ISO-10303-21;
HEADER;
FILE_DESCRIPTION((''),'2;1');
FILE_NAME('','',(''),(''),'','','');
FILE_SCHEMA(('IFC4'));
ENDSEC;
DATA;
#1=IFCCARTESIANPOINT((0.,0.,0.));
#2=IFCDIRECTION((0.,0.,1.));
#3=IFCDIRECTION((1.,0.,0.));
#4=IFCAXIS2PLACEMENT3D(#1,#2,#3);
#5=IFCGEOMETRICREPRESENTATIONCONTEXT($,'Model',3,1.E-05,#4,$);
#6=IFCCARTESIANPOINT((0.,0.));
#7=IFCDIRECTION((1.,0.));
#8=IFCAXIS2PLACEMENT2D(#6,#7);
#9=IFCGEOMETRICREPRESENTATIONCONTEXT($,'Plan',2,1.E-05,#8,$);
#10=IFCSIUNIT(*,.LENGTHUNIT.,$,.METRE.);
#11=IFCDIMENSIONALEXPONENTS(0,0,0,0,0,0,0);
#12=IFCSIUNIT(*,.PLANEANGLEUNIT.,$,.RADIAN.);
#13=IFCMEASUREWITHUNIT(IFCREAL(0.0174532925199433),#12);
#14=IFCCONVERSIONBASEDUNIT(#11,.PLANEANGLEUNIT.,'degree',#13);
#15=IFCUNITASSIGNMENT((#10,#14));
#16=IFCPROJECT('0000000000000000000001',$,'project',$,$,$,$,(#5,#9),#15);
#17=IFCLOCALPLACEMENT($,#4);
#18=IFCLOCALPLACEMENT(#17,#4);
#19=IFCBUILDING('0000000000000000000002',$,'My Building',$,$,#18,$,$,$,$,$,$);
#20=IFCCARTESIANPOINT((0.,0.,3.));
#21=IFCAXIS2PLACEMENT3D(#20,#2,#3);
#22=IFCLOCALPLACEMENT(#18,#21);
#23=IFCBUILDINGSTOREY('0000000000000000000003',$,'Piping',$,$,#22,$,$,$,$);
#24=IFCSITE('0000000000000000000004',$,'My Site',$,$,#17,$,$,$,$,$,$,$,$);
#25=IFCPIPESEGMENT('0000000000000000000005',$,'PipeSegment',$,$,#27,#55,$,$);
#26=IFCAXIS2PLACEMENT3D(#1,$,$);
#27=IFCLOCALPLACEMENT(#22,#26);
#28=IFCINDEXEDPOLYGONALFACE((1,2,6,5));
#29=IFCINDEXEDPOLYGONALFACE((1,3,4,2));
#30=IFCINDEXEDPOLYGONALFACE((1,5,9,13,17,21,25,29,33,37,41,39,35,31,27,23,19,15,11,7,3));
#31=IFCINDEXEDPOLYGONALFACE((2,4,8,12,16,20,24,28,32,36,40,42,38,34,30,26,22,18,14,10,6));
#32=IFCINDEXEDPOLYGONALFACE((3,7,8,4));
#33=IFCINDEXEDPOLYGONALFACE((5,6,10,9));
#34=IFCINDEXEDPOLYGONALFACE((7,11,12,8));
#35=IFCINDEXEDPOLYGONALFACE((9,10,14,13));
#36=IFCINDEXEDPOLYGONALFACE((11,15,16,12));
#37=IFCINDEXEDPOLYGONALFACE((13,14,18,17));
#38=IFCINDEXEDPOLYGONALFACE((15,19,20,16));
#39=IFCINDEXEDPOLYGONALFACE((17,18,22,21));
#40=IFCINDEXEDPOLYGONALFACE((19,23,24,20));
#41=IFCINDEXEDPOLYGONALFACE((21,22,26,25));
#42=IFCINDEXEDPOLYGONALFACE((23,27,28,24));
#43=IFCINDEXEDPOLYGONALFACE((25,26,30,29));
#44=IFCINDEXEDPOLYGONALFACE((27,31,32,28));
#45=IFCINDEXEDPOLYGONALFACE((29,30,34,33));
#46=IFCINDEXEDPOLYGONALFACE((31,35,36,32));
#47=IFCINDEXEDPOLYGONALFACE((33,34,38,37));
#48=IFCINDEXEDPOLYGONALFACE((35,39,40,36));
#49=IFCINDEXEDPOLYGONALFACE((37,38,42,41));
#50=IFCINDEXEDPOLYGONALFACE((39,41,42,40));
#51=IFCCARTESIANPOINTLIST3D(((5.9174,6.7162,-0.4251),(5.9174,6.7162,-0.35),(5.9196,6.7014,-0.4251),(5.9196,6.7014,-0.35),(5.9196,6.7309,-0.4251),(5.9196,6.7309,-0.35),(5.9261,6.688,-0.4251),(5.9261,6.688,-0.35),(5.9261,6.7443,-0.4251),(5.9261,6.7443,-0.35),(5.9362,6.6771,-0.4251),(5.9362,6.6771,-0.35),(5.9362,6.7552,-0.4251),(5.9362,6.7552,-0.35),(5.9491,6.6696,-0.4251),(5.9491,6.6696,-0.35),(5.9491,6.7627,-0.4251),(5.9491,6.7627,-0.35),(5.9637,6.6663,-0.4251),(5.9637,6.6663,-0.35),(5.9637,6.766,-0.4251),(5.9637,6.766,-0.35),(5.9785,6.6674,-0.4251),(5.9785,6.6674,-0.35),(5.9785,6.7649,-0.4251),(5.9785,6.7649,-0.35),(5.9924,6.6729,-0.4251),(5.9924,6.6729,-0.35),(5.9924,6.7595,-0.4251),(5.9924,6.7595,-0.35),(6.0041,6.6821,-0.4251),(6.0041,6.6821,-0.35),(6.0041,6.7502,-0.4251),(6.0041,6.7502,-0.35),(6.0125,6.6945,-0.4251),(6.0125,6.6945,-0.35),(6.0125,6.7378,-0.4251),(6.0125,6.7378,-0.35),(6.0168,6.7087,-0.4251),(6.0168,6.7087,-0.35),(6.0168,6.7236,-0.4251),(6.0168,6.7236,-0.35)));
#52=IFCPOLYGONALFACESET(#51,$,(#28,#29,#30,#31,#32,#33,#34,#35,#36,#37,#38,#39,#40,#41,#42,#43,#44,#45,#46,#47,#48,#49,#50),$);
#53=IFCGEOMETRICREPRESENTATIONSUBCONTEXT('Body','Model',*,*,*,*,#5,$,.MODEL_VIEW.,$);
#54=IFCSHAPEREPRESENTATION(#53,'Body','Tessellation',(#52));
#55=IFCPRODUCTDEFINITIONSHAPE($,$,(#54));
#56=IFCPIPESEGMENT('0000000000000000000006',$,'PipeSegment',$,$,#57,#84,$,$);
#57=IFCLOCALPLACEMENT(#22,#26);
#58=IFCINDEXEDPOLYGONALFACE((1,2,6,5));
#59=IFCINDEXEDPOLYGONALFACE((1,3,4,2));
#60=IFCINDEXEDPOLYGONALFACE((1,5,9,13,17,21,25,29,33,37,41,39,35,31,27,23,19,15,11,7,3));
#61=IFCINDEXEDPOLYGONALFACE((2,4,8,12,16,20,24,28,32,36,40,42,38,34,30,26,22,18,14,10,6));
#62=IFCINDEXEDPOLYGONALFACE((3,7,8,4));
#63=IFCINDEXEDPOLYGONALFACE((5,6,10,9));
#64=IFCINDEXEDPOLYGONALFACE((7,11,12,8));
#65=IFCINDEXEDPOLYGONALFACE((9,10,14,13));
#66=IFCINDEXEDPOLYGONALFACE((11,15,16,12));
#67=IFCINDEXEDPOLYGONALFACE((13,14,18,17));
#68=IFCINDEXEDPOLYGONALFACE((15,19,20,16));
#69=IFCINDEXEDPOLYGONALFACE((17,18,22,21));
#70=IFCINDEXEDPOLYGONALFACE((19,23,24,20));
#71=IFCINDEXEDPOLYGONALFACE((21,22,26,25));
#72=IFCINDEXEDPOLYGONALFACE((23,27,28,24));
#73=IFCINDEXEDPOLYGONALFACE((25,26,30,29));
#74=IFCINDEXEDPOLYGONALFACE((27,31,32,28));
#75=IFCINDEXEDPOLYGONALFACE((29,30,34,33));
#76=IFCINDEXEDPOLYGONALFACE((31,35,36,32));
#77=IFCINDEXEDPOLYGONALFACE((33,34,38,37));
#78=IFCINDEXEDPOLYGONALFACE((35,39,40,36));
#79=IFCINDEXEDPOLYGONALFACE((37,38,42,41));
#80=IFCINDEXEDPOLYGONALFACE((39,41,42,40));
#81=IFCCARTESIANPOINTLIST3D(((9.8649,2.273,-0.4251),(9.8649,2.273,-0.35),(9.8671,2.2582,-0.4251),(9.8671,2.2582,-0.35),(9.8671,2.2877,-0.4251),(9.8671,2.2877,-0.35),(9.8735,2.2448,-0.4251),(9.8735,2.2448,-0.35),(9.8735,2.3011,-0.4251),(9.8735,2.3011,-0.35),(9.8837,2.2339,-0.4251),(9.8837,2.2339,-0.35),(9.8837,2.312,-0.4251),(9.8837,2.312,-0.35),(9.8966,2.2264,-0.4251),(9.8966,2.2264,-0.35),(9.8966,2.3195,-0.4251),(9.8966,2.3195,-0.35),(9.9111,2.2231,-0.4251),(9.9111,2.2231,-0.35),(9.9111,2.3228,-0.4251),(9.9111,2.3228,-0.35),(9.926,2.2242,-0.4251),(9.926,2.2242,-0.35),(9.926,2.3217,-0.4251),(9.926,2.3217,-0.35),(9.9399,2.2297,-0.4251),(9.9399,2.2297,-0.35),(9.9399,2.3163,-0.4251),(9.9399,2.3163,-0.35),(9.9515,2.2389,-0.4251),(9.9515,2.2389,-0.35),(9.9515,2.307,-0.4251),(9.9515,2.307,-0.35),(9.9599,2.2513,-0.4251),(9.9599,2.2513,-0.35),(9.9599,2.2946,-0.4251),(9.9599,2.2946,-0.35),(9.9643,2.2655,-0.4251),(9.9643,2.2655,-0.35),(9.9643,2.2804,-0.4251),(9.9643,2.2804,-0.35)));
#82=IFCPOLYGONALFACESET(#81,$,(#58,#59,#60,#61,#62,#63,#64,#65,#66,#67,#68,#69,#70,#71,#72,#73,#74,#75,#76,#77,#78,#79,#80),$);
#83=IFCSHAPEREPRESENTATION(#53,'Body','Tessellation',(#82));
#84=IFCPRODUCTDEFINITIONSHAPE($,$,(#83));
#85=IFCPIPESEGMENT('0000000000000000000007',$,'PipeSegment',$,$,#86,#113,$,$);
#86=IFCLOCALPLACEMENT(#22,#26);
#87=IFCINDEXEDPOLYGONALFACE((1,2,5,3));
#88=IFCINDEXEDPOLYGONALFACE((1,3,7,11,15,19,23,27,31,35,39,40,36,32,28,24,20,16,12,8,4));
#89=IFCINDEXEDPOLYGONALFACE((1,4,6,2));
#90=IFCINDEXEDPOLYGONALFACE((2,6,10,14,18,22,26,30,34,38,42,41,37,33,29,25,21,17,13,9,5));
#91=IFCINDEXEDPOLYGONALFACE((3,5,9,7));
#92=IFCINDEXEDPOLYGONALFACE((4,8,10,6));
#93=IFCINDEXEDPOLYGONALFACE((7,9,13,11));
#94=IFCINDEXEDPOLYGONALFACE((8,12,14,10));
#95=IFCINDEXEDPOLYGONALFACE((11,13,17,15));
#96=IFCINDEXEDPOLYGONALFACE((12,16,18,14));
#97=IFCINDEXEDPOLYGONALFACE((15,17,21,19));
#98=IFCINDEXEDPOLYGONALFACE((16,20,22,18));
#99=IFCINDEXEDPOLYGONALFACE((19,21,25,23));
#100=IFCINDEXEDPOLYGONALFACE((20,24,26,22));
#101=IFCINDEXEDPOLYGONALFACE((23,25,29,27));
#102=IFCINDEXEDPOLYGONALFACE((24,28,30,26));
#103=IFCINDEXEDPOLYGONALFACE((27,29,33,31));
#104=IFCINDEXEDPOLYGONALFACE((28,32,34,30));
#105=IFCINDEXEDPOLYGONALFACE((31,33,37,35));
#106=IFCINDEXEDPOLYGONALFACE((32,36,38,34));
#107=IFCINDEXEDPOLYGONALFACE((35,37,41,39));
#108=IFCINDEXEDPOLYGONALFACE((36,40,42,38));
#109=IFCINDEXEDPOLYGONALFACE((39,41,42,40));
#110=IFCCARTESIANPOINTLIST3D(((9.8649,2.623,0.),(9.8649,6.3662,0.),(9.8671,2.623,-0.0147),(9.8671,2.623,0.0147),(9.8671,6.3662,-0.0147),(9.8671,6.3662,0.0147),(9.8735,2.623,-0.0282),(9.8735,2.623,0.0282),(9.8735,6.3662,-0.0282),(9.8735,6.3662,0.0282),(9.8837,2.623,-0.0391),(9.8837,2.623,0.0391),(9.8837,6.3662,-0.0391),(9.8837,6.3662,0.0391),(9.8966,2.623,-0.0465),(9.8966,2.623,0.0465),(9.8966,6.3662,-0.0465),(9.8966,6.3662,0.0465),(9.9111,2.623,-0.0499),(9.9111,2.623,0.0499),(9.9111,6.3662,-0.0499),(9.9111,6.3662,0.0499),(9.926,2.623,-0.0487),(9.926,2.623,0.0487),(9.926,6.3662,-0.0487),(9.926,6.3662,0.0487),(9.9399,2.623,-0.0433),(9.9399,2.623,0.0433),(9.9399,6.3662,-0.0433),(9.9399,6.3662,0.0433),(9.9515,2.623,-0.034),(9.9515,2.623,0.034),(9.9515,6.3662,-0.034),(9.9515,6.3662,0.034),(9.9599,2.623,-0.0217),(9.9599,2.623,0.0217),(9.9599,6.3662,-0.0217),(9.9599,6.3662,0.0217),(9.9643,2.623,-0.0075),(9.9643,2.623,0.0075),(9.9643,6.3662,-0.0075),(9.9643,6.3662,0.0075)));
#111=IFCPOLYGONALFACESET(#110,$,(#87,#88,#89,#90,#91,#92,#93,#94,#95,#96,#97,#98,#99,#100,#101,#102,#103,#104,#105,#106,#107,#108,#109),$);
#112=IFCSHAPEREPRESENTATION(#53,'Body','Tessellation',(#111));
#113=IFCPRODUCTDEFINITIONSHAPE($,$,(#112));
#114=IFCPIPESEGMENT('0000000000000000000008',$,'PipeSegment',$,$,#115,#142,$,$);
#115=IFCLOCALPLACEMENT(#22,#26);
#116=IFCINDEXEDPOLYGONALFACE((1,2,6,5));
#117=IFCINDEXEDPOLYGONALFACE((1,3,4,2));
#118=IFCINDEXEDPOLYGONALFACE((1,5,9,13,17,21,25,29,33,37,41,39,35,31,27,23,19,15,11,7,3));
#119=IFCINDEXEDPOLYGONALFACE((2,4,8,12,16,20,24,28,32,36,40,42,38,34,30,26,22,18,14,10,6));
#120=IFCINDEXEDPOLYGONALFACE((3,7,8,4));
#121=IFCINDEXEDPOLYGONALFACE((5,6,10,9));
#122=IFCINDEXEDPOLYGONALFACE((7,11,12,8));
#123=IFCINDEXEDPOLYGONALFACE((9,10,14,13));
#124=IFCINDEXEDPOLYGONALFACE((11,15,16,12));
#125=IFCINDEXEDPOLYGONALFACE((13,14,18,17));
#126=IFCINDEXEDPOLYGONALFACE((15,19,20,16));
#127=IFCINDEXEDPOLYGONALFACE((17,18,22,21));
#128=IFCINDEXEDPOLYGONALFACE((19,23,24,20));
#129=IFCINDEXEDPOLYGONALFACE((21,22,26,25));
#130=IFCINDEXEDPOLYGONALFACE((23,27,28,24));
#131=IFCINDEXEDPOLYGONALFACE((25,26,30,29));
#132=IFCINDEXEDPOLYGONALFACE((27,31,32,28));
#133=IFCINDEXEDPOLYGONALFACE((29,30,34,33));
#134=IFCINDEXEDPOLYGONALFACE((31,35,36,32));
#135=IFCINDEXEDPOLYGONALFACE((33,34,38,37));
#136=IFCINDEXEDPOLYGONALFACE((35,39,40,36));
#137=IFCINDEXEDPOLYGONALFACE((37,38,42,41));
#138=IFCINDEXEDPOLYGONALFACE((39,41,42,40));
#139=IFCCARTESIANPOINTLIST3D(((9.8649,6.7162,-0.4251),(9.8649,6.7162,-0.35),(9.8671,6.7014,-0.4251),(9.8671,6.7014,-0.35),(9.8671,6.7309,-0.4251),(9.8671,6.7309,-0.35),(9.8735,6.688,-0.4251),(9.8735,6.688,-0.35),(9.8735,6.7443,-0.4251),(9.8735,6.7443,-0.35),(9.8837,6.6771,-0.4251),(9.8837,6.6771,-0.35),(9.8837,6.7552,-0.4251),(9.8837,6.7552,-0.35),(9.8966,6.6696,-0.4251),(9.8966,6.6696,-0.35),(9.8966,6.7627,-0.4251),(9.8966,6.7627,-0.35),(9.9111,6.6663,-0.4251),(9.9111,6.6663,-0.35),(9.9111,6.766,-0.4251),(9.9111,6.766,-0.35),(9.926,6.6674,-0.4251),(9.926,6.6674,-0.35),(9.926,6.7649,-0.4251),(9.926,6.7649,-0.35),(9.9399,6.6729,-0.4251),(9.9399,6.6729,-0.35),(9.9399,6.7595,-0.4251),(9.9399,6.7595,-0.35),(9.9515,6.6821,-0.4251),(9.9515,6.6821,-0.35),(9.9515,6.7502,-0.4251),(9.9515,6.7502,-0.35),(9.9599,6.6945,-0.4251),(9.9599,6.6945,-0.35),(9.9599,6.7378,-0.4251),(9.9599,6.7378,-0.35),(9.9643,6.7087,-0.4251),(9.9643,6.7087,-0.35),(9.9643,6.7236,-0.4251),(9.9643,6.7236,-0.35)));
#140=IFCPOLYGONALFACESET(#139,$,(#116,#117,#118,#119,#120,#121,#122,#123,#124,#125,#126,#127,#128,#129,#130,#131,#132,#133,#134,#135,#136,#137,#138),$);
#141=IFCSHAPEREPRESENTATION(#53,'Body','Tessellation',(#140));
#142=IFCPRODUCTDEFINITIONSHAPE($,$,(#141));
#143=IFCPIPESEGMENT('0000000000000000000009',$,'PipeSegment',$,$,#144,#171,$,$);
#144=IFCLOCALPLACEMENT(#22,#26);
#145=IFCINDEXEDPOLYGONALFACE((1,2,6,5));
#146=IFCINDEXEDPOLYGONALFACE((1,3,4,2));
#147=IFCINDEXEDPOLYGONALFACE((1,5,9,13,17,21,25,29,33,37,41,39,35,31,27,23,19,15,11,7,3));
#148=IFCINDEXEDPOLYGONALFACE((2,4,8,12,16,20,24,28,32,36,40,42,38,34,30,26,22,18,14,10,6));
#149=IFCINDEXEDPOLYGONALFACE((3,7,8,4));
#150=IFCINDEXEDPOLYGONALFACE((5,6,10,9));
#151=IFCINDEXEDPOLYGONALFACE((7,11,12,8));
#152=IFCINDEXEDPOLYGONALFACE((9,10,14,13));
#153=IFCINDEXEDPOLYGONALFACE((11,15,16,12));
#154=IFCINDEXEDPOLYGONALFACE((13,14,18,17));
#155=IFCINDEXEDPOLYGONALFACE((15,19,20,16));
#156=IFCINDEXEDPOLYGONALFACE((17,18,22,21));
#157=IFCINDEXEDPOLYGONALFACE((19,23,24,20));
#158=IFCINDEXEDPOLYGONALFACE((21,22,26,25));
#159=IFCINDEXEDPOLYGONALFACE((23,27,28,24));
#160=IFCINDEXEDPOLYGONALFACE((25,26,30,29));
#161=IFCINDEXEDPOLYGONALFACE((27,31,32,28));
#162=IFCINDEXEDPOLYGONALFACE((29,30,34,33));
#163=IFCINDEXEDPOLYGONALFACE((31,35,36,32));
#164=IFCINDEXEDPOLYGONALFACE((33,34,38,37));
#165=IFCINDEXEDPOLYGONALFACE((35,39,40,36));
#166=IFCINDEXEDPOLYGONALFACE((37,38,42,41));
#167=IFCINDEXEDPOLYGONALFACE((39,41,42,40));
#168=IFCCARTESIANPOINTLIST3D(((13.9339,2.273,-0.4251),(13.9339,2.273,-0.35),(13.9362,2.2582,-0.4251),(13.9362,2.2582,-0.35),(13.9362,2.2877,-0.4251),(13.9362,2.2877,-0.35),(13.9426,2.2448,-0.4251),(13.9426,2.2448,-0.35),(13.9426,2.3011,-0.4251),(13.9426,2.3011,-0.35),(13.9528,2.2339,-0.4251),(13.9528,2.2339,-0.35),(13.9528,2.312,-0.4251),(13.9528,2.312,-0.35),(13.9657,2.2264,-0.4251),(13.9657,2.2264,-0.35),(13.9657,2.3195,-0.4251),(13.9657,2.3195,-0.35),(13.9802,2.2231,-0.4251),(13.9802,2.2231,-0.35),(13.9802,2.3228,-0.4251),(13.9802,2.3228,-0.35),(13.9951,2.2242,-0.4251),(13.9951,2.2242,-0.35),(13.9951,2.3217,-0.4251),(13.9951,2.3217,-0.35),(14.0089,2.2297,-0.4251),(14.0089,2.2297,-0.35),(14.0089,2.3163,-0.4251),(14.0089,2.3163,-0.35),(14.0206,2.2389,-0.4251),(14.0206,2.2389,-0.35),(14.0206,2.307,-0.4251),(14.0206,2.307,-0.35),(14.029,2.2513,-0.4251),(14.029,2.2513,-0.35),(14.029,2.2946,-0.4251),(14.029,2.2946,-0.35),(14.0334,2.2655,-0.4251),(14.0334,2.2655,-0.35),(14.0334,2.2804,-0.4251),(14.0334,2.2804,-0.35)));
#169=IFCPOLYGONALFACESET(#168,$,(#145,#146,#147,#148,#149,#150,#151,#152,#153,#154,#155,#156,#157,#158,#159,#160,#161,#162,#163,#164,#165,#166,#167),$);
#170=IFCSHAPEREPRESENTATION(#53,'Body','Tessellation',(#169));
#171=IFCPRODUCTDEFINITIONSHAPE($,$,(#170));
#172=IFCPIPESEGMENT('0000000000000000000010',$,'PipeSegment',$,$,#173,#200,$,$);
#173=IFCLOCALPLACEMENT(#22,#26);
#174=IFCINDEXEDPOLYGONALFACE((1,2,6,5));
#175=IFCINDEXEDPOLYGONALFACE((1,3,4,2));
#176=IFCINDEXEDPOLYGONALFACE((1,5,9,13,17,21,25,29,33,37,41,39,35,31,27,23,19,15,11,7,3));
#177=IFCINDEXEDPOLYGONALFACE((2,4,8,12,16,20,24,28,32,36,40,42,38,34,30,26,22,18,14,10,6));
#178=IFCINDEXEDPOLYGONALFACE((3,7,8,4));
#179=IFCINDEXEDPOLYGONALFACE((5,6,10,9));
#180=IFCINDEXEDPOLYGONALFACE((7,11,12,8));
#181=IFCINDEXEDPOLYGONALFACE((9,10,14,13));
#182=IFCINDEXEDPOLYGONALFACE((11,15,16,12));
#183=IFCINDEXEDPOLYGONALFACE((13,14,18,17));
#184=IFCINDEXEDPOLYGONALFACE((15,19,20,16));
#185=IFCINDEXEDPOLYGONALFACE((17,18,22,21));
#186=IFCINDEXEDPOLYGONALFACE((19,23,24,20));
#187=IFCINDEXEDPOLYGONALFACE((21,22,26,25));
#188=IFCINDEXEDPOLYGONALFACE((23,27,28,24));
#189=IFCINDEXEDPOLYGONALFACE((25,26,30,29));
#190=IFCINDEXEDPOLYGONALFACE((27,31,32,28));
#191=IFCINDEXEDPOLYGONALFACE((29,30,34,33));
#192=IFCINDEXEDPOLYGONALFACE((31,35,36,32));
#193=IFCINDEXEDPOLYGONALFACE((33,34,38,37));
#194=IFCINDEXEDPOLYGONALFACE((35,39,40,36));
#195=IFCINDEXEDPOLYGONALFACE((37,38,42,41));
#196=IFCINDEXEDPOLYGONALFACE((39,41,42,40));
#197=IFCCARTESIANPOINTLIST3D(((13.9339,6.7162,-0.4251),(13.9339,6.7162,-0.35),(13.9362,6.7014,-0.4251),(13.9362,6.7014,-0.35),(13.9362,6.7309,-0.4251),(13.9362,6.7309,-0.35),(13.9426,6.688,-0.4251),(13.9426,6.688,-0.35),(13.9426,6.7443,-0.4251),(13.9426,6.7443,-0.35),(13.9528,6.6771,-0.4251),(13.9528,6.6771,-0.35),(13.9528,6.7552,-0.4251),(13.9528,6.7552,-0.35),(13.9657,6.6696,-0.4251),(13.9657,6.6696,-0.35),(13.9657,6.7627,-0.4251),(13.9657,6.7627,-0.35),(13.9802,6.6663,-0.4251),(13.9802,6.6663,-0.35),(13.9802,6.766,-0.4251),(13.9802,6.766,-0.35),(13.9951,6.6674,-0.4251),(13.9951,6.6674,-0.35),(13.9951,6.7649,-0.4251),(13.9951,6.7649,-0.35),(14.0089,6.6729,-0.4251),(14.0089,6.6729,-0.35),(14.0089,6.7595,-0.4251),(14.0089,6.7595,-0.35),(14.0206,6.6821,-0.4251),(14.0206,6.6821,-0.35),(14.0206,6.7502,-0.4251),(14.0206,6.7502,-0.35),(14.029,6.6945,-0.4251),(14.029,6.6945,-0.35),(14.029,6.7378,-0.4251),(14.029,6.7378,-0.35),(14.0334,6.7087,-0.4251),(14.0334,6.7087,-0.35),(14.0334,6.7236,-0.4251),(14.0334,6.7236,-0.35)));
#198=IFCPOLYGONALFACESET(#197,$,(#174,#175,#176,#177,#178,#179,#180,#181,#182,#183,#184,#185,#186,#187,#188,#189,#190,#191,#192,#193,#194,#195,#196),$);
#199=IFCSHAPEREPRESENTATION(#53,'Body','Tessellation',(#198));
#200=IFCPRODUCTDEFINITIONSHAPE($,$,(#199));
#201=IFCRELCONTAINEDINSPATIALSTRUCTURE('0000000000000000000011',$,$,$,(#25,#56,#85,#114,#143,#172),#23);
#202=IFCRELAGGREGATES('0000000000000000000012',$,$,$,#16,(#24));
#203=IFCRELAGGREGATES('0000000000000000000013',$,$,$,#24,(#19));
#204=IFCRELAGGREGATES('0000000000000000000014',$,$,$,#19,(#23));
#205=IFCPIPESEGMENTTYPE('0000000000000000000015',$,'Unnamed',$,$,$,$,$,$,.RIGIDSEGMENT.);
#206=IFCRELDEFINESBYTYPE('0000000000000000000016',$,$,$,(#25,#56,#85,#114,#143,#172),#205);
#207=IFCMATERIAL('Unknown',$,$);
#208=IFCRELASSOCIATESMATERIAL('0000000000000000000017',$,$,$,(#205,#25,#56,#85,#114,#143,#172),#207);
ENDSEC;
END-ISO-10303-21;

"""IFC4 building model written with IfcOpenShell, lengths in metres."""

from ifc_helpers import new_model, entity, si_unit, converted_unit, frame, origin_with_axes, origin_2d_with_axis, place, context, subcontext, project, spatial, circle, extrude, material, material_profile, profile_set, profile_usage, type_object, element, save


model = new_model("IFC4")

# Units and contexts
model_context = context("Model", 3, precision=1e-05, world=origin_with_axes())
plan_context = context("Plan", 2, precision=1e-05, world=origin_2d_with_axis())
body_context = subcontext(model_context, "Body", "Model", "MODEL_VIEW")
ifc_project = project(units=[si_unit("LENGTHUNIT", "METRE"), converted_unit("PLANEANGLEUNIT", "degree", entity("IfcReal", 0.0174532925199433), si_unit("PLANEANGLEUNIT", "RADIAN"), dimensions=[0, 0, 0, 0, 0, 0, 0])], contexts=[model_context, plan_context])

# Site, building, storey
site_placement = place(None, origin_with_axes())
site = spatial("IfcSite", under=ifc_project, at=site_placement, Name="My Site")
building_placement = place(site_placement, origin_with_axes())
building = spatial("IfcBuilding", under=site, at=building_placement, Name="My Building")
storey_placement = place(building_placement, frame((0.0, 0.0, 3.0), z_axis=(0.0, 0.0, 1.0), x_axis=(1.0, 0.0, 0.0)))
storey = spatial("IfcBuildingStorey", under=building, at=storey_placement, Name="Piping")

# Pipe segments
ifc_material = material(Name="Unknown")
ifc_material_profile = material_profile(ifc_material, circle(Radius=0.05))
ifc_profile_set = profile_set([ifc_material_profile])
pipe_segment_type = type_object("IfcPipeSegmentType", Name="Unnamed", PredefinedType="RIGIDSEGMENT", material=ifc_profile_set)
ifc_profile_usage_1 = profile_usage(ifc_profile_set, cardinal=5)
pipe_segment_1_placement = place(storey_placement, frame((5.9674, 6.7162, -0.35), z_axis=(0.0, 0.0, -1.0), x_axis=(-1.0, 0.0, 0.0)))
element("IfcPipeSegment", 1, at=pipe_segment_1_placement, inside=storey, type_object=pipe_segment_type, material=ifc_profile_usage_1, Name="PipeSegment", context=body_context, shape_type="SweptSolid", body=[
    extrude(circle(Radius=0.05), origin_with_axes(), (0.0, 0.0, 1.0), 0.0751),
])
ifc_profile_usage_2 = profile_usage(ifc_profile_set, cardinal=5)
pipe_segment_2_placement = place(storey_placement, frame((9.9149, 2.273, -0.35), z_axis=(0.0, 0.0, -1.0), x_axis=(-1.0, 0.0, 0.0)))
element("IfcPipeSegment", 2, at=pipe_segment_2_placement, inside=storey, type_object=pipe_segment_type, material=ifc_profile_usage_2, Name="PipeSegment", context=body_context, shape_type="SweptSolid", body=[
    extrude(circle(Radius=0.05), origin_with_axes(), (0.0, 0.0, 1.0), 0.0751),
])
ifc_profile_usage_3 = profile_usage(ifc_profile_set, cardinal=5)
pipe_segment_3_placement = place(storey_placement, frame((9.9149, 2.623, 0.0), z_axis=(0.0, 1.0, 0.0), x_axis=(-1.0, 0.0, 0.0)))
element("IfcPipeSegment", 3, at=pipe_segment_3_placement, inside=storey, type_object=pipe_segment_type, material=ifc_profile_usage_3, Name="PipeSegment", context=body_context, shape_type="SweptSolid", body=[
    extrude(circle(Radius=0.05), origin_with_axes(), (0.0, 0.0, 1.0), 3.7432),
])
ifc_profile_usage_4 = profile_usage(ifc_profile_set, cardinal=5)
pipe_segment_4_placement = place(storey_placement, frame((9.9149, 6.7162, -0.35), z_axis=(0.0, 0.0, -1.0), x_axis=(-1.0, 0.0, 0.0)))
element("IfcPipeSegment", 4, at=pipe_segment_4_placement, inside=storey, type_object=pipe_segment_type, material=ifc_profile_usage_4, Name="PipeSegment", context=body_context, shape_type="SweptSolid", body=[
    extrude(circle(Radius=0.05), origin_with_axes(), (0.0, 0.0, 1.0), 0.0751),
])
ifc_profile_usage_5 = profile_usage(ifc_profile_set, cardinal=5)
pipe_segment_5_placement = place(storey_placement, frame((13.9839, 2.273, -0.35), z_axis=(0.0, 0.0, -1.0), x_axis=(-1.0, 0.0, 0.0)))
element("IfcPipeSegment", 5, at=pipe_segment_5_placement, inside=storey, type_object=pipe_segment_type, material=ifc_profile_usage_5, Name="PipeSegment", context=body_context, shape_type="SweptSolid", body=[
    extrude(circle(Radius=0.05), origin_with_axes(), (0.0, 0.0, 1.0), 0.0751),
])
ifc_profile_usage_6 = profile_usage(ifc_profile_set, cardinal=5)
pipe_segment_6_placement = place(storey_placement, frame((13.9839, 6.7162, -0.35), z_axis=(0.0, 0.0, -1.0), x_axis=(-1.0, 0.0, 0.0)))
element("IfcPipeSegment", 6, at=pipe_segment_6_placement, inside=storey, type_object=pipe_segment_type, material=ifc_profile_usage_6, Name="PipeSegment", context=body_context, shape_type="SweptSolid", body=[
    extrude(circle(Radius=0.05), origin_with_axes(), (0.0, 0.0, 1.0), 0.0751),
])

save(model, "model.ifc")
